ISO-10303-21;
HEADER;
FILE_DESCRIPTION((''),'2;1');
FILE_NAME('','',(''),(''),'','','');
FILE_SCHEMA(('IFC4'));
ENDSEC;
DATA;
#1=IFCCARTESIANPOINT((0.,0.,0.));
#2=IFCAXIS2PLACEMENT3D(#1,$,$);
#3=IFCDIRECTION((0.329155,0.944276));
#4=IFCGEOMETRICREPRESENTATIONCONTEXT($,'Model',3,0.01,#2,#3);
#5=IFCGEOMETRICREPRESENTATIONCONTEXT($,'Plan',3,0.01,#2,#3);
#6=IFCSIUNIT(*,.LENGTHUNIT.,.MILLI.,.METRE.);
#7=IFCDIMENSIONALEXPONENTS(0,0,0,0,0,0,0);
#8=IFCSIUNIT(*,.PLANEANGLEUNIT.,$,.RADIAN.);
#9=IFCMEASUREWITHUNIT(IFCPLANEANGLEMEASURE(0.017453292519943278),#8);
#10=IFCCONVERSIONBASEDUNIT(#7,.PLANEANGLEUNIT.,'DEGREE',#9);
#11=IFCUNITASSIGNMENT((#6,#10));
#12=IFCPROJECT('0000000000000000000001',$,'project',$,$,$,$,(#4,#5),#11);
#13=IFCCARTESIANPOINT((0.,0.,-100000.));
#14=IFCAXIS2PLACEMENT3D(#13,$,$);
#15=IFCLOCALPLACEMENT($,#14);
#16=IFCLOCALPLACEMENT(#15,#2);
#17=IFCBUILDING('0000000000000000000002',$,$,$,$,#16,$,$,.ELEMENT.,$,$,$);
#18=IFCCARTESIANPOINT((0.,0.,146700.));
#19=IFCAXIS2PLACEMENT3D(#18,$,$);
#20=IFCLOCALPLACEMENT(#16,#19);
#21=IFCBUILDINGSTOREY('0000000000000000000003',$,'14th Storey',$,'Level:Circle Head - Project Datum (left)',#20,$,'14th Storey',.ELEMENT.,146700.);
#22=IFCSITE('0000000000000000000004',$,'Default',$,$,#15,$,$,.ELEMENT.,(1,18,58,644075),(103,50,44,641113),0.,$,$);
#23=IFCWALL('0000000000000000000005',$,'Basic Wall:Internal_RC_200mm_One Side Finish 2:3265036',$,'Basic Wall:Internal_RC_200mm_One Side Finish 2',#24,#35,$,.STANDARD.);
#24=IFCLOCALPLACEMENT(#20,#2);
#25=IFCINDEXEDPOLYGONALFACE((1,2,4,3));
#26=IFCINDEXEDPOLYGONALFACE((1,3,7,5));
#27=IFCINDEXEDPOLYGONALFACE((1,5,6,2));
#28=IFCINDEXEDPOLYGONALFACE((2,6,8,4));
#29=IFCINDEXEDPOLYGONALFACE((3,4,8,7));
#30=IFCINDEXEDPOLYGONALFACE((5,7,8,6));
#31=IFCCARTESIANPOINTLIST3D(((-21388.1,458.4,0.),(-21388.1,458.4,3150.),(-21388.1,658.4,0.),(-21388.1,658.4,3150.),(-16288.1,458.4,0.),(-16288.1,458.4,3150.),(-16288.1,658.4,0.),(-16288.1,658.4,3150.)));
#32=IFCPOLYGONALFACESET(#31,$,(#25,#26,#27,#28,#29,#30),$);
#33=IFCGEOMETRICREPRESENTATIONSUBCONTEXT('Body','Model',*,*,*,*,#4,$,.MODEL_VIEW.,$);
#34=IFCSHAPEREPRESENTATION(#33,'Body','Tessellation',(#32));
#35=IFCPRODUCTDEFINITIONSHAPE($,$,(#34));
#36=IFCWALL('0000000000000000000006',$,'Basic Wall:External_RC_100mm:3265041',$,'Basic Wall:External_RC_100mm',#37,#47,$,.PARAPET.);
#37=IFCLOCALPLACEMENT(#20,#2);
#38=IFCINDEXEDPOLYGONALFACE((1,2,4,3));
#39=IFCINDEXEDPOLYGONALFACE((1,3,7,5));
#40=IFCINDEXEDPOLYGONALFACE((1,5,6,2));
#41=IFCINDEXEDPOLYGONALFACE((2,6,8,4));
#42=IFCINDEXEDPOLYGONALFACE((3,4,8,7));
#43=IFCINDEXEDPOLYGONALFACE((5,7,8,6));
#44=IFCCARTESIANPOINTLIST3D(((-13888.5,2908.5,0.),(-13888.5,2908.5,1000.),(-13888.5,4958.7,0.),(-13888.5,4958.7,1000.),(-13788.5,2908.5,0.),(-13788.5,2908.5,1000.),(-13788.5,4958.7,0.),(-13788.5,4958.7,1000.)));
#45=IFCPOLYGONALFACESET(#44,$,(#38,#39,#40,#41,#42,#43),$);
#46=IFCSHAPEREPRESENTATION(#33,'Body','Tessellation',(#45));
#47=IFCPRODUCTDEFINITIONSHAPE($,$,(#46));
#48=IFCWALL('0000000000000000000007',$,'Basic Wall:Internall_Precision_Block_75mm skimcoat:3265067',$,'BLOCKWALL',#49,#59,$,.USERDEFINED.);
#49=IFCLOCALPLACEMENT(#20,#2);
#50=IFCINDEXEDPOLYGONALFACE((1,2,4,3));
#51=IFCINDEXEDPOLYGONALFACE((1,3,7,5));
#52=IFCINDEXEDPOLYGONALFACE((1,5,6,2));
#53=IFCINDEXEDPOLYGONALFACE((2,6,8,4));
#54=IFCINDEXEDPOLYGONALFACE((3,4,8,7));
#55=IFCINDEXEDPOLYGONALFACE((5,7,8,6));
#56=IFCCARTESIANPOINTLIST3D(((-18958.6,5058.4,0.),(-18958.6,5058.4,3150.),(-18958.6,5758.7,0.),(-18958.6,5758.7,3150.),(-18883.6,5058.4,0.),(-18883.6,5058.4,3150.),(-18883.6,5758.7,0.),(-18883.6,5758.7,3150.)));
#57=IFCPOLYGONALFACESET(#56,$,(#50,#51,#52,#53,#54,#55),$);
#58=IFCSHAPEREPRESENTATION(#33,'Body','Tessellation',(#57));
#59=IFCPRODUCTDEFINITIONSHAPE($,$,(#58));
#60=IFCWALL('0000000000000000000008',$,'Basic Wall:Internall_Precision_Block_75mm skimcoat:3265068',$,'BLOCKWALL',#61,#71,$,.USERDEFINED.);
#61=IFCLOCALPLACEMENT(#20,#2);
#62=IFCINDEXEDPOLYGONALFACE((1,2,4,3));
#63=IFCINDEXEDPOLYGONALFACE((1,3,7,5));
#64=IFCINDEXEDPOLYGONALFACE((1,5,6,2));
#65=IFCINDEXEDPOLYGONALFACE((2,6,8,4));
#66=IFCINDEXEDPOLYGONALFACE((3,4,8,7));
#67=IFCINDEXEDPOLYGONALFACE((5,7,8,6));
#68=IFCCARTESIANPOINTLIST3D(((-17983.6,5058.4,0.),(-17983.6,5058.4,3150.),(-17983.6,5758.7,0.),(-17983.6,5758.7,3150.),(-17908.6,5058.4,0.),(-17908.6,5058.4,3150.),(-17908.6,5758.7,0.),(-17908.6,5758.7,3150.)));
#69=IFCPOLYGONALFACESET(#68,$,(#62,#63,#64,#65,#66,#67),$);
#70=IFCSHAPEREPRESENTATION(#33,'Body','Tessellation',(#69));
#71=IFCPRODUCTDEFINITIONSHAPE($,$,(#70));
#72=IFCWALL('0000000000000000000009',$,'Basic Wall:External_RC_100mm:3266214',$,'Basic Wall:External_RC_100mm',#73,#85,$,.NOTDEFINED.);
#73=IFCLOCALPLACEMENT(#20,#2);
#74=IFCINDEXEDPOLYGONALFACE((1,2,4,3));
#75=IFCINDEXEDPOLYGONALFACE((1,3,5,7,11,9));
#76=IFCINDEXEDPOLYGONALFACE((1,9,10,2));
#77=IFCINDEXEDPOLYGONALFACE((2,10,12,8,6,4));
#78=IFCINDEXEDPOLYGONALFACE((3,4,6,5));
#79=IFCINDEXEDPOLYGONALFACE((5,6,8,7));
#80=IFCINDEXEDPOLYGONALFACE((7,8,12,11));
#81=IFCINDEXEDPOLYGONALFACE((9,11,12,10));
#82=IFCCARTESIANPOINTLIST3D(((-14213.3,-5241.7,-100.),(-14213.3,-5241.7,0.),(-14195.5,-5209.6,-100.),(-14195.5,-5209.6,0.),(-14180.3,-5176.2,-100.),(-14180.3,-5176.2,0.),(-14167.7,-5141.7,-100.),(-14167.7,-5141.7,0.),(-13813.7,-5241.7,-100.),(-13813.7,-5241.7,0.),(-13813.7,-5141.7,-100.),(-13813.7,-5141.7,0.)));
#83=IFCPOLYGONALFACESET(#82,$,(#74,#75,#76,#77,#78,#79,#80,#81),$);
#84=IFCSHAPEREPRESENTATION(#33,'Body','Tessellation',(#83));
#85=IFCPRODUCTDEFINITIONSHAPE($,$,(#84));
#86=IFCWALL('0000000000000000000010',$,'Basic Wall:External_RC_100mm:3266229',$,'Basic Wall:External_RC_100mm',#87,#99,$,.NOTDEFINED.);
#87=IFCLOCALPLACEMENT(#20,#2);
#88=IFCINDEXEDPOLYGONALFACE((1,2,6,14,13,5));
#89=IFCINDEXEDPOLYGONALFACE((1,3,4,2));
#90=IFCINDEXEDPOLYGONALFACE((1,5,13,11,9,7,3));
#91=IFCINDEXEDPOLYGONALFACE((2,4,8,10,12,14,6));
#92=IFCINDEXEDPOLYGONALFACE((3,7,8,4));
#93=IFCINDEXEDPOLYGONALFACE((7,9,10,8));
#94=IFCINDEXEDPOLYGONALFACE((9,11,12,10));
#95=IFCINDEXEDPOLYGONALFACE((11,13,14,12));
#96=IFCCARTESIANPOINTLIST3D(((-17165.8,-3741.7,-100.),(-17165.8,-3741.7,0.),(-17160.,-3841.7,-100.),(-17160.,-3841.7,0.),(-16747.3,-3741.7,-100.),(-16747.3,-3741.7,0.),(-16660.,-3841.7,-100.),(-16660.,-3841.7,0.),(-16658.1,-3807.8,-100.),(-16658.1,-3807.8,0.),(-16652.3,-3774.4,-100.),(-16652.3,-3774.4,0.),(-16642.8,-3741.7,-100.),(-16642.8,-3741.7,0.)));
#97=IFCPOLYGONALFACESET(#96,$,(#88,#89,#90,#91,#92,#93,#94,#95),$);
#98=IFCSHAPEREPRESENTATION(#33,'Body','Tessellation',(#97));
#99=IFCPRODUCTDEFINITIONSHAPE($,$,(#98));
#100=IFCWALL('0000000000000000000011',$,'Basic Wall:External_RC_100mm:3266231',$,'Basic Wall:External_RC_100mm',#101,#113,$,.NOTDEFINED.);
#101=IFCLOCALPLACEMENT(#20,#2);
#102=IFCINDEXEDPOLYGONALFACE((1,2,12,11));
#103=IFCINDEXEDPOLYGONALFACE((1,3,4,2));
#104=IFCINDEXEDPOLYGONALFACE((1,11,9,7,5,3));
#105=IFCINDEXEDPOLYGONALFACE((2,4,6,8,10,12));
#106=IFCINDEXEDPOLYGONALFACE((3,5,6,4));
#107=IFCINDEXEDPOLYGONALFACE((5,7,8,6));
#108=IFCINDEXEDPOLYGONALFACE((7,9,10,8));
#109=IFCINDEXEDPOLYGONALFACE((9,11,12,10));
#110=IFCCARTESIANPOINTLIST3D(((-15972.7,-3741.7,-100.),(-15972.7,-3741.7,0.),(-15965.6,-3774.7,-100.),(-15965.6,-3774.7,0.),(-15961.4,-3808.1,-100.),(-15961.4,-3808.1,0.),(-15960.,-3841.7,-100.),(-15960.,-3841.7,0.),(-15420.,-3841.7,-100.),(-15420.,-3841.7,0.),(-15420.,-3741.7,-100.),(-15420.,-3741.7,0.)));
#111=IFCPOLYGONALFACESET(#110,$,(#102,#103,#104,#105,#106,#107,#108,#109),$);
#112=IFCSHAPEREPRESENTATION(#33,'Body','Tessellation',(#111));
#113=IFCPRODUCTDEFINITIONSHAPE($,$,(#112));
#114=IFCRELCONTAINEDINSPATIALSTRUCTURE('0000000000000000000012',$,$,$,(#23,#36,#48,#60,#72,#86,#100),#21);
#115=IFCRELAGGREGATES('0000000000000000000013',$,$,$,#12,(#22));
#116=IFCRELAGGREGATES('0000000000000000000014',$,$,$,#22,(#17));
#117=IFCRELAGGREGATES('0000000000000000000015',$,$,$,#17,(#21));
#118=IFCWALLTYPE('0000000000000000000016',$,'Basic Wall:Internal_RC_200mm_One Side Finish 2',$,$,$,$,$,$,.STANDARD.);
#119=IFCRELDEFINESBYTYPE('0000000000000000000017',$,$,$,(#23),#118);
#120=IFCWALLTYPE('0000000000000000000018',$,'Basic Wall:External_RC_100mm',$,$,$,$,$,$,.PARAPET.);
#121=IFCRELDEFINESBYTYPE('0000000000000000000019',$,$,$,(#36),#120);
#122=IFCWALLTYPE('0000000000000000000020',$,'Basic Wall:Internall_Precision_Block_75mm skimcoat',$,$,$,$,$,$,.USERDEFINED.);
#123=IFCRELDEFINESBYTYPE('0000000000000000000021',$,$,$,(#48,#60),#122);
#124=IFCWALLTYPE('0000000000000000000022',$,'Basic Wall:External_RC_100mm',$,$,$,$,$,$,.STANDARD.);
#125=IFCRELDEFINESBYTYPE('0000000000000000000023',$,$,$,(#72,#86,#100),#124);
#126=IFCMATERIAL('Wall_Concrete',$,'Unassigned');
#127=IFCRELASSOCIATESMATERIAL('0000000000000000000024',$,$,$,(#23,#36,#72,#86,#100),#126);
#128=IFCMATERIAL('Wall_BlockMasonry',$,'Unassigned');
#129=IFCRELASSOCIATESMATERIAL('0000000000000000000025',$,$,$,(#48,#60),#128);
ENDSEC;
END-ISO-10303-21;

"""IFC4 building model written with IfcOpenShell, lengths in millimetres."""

from ifc_helpers import new_model, entity, si_unit, converted_unit, direction, frame, origin, place, context, subcontext, project, spatial, line, arc, indexed_curve, outline, extrude, material, type_object, element, save


model = new_model("IFC4")

# Units and contexts
model_context = context("Model", 3, precision=0.01, world=origin(), true_north=direction((0.329155, 0.944276)))
plan_context = context("Plan", 3, precision=0.01, world=origin(), true_north=direction((0.329155, 0.944276)))
body_context = subcontext(model_context, "Body", "Model", "MODEL_VIEW")
ifc_project = project(units=[si_unit("LENGTHUNIT", "METRE", prefix="MILLI"), converted_unit("PLANEANGLEUNIT", "DEGREE", entity("IfcPlaneAngleMeasure", 0.017453292519943278), si_unit("PLANEANGLEUNIT", "RADIAN"), dimensions=[0, 0, 0, 0, 0, 0, 0])], contexts=[model_context, plan_context])

# Site, building, storey
site_placement = place(None, frame((0.0, 0.0, -100000.0)))
site = spatial("IfcSite", under=ifc_project, at=site_placement, Name="Default", CompositionType="ELEMENT", RefLatitude=(1, 18, 58, 644075), RefLongitude=(103, 50, 44, 641113), RefElevation=0.0)
building_placement = place(site_placement, origin())
building = spatial("IfcBuilding", under=site, at=building_placement, CompositionType="ELEMENT")
storey_placement = place(building_placement, frame((0.0, 0.0, 146700.0)))
storey = spatial("IfcBuildingStorey", under=building, at=storey_placement, Name="14th Storey", ObjectType="Level:Circle Head - Project Datum (left)", LongName="14th Storey", CompositionType="ELEMENT", Elevation=146700.0)

# Walls
ifc_material_1 = material(Name="Wall_Concrete", Category="Unassigned")
wall_type_1 = type_object("IfcWallType", Name="Basic Wall:Internal_RC_200mm_One Side Finish 2", PredefinedType="STANDARD")
wall_1_placement = place(storey_placement, frame((-16288.1, 558.4, 0.0), z_axis=(0.0, 0.0, 1.0), x_axis=(-1.0, 0.0, 0.0)))
element("IfcWall", 1, at=wall_1_placement, inside=storey, type_object=wall_type_1, material=ifc_material_1, Name="Basic Wall:Internal_RC_200mm_One Side Finish 2:3265036", ObjectType="Basic Wall:Internal_RC_200mm_One Side Finish 2", PredefinedType="STANDARD", context=body_context, shape_type="SweptSolid", body=[
    extrude(outline(indexed_curve([(5100.0, 100.0), (0.0, 100.0), (0.0, -100.0), (5100.0, -100.0), (5100.0, 100.0)], self_intersect=False)), origin(), (0.0, 0.0, 1.0), 3150.0),
])
wall_type_2 = type_object("IfcWallType", Name="Basic Wall:External_RC_100mm", PredefinedType="PARAPET")
wall_2_placement = place(storey_placement, frame((-13838.5, 4958.7, 0.0), z_axis=(0.0, 0.0, 1.0), x_axis=(0.0, -1.0, 0.0)))
element("IfcWall", 2, at=wall_2_placement, inside=storey, type_object=wall_type_2, material=ifc_material_1, Name="Basic Wall:External_RC_100mm:3265041", ObjectType="Basic Wall:External_RC_100mm", PredefinedType="PARAPET", context=body_context, shape_type="SweptSolid", body=[
    extrude(outline(indexed_curve([(2050.3, 50.0), (0.0, 50.0), (0.0, -50.0), (2050.3, -50.0), (2050.3, 50.0)], self_intersect=False)), origin(), (0.0, 0.0, 1.0), 1000.0),
])
ifc_material_2 = material(Name="Wall_BlockMasonry", Category="Unassigned")
wall_type_3 = type_object("IfcWallType", Name="Basic Wall:Internall_Precision_Block_75mm skimcoat", PredefinedType="USERDEFINED")
wall_3_placement = place(storey_placement, frame((-18921.1, 5058.4, 0.0), z_axis=(0.0, 0.0, 1.0), x_axis=(0.0, 1.0, 0.0)))
element("IfcWall", 3, at=wall_3_placement, inside=storey, type_object=wall_type_3, material=ifc_material_2, Name="Basic Wall:Internall_Precision_Block_75mm skimcoat:3265067", ObjectType="BLOCKWALL", PredefinedType="USERDEFINED", context=body_context, shape_type="SweptSolid", body=[
    extrude(outline(indexed_curve([(700.4, 37.5), (0.0, 37.5), (0.0, -37.5), (700.4, -37.5), (700.4, 37.5)], self_intersect=False)), origin(), (0.0, 0.0, 1.0), 3150.0),
])
wall_4_placement = place(storey_placement, frame((-17946.1, 5058.4, 0.0), z_axis=(0.0, 0.0, 1.0), x_axis=(0.0, 1.0, 0.0)))
element("IfcWall", 4, at=wall_4_placement, inside=storey, type_object=wall_type_3, material=ifc_material_2, Name="Basic Wall:Internall_Precision_Block_75mm skimcoat:3265068", ObjectType="BLOCKWALL", PredefinedType="USERDEFINED", context=body_context, shape_type="SweptSolid", body=[
    extrude(outline(indexed_curve([(700.4, 37.5), (0.0, 37.5), (0.0, -37.5), (700.4, -37.5), (700.4, 37.5)], self_intersect=False)), origin(), (0.0, 0.0, 1.0), 3150.0),
])
wall_type_4 = type_object("IfcWallType", Name="Basic Wall:External_RC_100mm", PredefinedType="STANDARD")
wall_5_placement = place(storey_placement, frame((-14213.3, -5191.7, -100.0)))
element("IfcWall", 5, at=wall_5_placement, inside=storey, type_object=wall_type_4, material=ifc_material_1, Name="Basic Wall:External_RC_100mm:3266214", ObjectType="Basic Wall:External_RC_100mm", PredefinedType="NOTDEFINED", context=body_context, shape_type="SweptSolid", body=[
    extrude(outline(indexed_curve([(399.6, -50.0), (399.6, 50.0), (45.7, 50.0), (25.8, -1.3), (0.0, -50.0)], segments=[line(1, 2, 3), arc(3, 4, 5), line(5, 1)], self_intersect=False)), origin(), (0.0, 0.0, 1.0), 100.0),
])
wall_6_placement = place(storey_placement, frame((-17165.8, -3791.7, -100.0)))
element("IfcWall", 6, at=wall_6_placement, inside=storey, type_object=wall_type_4, material=ifc_material_1, Name="Basic Wall:External_RC_100mm:3266229", ObjectType="Basic Wall:External_RC_100mm", PredefinedType="NOTDEFINED", context=body_context, shape_type="SweptSolid", body=[
    extrude(outline(indexed_curve([(505.8, -50.0), (510.2, 0.7), (523.0, 50.0), (418.5, 50.0), (0.0, 50.0), (5.8, -50.0)], segments=[arc(1, 2, 3), line(3, 4, 5, 6, 1)], self_intersect=False)), origin(), (0.0, 0.0, 1.0), 100.0),
])
wall_7_placement = place(storey_placement, frame((-15972.7, -3791.7, -100.0)))
element("IfcWall", 7, at=wall_7_placement, inside=storey, type_object=wall_type_4, material=ifc_material_1, Name="Basic Wall:External_RC_100mm:3266231", ObjectType="Basic Wall:External_RC_100mm", PredefinedType="NOTDEFINED", context=body_context, shape_type="SweptSolid", body=[
    extrude(outline(indexed_curve([(552.7, -50.0), (552.7, 50.0), (0.0, 50.0), (9.5, 0.4), (12.7, -50.0)], segments=[line(1, 2, 3), arc(3, 4, 5), line(5, 1)], self_intersect=False)), origin(), (0.0, 0.0, 1.0), 100.0),
])

save(model, "model.ifc")
